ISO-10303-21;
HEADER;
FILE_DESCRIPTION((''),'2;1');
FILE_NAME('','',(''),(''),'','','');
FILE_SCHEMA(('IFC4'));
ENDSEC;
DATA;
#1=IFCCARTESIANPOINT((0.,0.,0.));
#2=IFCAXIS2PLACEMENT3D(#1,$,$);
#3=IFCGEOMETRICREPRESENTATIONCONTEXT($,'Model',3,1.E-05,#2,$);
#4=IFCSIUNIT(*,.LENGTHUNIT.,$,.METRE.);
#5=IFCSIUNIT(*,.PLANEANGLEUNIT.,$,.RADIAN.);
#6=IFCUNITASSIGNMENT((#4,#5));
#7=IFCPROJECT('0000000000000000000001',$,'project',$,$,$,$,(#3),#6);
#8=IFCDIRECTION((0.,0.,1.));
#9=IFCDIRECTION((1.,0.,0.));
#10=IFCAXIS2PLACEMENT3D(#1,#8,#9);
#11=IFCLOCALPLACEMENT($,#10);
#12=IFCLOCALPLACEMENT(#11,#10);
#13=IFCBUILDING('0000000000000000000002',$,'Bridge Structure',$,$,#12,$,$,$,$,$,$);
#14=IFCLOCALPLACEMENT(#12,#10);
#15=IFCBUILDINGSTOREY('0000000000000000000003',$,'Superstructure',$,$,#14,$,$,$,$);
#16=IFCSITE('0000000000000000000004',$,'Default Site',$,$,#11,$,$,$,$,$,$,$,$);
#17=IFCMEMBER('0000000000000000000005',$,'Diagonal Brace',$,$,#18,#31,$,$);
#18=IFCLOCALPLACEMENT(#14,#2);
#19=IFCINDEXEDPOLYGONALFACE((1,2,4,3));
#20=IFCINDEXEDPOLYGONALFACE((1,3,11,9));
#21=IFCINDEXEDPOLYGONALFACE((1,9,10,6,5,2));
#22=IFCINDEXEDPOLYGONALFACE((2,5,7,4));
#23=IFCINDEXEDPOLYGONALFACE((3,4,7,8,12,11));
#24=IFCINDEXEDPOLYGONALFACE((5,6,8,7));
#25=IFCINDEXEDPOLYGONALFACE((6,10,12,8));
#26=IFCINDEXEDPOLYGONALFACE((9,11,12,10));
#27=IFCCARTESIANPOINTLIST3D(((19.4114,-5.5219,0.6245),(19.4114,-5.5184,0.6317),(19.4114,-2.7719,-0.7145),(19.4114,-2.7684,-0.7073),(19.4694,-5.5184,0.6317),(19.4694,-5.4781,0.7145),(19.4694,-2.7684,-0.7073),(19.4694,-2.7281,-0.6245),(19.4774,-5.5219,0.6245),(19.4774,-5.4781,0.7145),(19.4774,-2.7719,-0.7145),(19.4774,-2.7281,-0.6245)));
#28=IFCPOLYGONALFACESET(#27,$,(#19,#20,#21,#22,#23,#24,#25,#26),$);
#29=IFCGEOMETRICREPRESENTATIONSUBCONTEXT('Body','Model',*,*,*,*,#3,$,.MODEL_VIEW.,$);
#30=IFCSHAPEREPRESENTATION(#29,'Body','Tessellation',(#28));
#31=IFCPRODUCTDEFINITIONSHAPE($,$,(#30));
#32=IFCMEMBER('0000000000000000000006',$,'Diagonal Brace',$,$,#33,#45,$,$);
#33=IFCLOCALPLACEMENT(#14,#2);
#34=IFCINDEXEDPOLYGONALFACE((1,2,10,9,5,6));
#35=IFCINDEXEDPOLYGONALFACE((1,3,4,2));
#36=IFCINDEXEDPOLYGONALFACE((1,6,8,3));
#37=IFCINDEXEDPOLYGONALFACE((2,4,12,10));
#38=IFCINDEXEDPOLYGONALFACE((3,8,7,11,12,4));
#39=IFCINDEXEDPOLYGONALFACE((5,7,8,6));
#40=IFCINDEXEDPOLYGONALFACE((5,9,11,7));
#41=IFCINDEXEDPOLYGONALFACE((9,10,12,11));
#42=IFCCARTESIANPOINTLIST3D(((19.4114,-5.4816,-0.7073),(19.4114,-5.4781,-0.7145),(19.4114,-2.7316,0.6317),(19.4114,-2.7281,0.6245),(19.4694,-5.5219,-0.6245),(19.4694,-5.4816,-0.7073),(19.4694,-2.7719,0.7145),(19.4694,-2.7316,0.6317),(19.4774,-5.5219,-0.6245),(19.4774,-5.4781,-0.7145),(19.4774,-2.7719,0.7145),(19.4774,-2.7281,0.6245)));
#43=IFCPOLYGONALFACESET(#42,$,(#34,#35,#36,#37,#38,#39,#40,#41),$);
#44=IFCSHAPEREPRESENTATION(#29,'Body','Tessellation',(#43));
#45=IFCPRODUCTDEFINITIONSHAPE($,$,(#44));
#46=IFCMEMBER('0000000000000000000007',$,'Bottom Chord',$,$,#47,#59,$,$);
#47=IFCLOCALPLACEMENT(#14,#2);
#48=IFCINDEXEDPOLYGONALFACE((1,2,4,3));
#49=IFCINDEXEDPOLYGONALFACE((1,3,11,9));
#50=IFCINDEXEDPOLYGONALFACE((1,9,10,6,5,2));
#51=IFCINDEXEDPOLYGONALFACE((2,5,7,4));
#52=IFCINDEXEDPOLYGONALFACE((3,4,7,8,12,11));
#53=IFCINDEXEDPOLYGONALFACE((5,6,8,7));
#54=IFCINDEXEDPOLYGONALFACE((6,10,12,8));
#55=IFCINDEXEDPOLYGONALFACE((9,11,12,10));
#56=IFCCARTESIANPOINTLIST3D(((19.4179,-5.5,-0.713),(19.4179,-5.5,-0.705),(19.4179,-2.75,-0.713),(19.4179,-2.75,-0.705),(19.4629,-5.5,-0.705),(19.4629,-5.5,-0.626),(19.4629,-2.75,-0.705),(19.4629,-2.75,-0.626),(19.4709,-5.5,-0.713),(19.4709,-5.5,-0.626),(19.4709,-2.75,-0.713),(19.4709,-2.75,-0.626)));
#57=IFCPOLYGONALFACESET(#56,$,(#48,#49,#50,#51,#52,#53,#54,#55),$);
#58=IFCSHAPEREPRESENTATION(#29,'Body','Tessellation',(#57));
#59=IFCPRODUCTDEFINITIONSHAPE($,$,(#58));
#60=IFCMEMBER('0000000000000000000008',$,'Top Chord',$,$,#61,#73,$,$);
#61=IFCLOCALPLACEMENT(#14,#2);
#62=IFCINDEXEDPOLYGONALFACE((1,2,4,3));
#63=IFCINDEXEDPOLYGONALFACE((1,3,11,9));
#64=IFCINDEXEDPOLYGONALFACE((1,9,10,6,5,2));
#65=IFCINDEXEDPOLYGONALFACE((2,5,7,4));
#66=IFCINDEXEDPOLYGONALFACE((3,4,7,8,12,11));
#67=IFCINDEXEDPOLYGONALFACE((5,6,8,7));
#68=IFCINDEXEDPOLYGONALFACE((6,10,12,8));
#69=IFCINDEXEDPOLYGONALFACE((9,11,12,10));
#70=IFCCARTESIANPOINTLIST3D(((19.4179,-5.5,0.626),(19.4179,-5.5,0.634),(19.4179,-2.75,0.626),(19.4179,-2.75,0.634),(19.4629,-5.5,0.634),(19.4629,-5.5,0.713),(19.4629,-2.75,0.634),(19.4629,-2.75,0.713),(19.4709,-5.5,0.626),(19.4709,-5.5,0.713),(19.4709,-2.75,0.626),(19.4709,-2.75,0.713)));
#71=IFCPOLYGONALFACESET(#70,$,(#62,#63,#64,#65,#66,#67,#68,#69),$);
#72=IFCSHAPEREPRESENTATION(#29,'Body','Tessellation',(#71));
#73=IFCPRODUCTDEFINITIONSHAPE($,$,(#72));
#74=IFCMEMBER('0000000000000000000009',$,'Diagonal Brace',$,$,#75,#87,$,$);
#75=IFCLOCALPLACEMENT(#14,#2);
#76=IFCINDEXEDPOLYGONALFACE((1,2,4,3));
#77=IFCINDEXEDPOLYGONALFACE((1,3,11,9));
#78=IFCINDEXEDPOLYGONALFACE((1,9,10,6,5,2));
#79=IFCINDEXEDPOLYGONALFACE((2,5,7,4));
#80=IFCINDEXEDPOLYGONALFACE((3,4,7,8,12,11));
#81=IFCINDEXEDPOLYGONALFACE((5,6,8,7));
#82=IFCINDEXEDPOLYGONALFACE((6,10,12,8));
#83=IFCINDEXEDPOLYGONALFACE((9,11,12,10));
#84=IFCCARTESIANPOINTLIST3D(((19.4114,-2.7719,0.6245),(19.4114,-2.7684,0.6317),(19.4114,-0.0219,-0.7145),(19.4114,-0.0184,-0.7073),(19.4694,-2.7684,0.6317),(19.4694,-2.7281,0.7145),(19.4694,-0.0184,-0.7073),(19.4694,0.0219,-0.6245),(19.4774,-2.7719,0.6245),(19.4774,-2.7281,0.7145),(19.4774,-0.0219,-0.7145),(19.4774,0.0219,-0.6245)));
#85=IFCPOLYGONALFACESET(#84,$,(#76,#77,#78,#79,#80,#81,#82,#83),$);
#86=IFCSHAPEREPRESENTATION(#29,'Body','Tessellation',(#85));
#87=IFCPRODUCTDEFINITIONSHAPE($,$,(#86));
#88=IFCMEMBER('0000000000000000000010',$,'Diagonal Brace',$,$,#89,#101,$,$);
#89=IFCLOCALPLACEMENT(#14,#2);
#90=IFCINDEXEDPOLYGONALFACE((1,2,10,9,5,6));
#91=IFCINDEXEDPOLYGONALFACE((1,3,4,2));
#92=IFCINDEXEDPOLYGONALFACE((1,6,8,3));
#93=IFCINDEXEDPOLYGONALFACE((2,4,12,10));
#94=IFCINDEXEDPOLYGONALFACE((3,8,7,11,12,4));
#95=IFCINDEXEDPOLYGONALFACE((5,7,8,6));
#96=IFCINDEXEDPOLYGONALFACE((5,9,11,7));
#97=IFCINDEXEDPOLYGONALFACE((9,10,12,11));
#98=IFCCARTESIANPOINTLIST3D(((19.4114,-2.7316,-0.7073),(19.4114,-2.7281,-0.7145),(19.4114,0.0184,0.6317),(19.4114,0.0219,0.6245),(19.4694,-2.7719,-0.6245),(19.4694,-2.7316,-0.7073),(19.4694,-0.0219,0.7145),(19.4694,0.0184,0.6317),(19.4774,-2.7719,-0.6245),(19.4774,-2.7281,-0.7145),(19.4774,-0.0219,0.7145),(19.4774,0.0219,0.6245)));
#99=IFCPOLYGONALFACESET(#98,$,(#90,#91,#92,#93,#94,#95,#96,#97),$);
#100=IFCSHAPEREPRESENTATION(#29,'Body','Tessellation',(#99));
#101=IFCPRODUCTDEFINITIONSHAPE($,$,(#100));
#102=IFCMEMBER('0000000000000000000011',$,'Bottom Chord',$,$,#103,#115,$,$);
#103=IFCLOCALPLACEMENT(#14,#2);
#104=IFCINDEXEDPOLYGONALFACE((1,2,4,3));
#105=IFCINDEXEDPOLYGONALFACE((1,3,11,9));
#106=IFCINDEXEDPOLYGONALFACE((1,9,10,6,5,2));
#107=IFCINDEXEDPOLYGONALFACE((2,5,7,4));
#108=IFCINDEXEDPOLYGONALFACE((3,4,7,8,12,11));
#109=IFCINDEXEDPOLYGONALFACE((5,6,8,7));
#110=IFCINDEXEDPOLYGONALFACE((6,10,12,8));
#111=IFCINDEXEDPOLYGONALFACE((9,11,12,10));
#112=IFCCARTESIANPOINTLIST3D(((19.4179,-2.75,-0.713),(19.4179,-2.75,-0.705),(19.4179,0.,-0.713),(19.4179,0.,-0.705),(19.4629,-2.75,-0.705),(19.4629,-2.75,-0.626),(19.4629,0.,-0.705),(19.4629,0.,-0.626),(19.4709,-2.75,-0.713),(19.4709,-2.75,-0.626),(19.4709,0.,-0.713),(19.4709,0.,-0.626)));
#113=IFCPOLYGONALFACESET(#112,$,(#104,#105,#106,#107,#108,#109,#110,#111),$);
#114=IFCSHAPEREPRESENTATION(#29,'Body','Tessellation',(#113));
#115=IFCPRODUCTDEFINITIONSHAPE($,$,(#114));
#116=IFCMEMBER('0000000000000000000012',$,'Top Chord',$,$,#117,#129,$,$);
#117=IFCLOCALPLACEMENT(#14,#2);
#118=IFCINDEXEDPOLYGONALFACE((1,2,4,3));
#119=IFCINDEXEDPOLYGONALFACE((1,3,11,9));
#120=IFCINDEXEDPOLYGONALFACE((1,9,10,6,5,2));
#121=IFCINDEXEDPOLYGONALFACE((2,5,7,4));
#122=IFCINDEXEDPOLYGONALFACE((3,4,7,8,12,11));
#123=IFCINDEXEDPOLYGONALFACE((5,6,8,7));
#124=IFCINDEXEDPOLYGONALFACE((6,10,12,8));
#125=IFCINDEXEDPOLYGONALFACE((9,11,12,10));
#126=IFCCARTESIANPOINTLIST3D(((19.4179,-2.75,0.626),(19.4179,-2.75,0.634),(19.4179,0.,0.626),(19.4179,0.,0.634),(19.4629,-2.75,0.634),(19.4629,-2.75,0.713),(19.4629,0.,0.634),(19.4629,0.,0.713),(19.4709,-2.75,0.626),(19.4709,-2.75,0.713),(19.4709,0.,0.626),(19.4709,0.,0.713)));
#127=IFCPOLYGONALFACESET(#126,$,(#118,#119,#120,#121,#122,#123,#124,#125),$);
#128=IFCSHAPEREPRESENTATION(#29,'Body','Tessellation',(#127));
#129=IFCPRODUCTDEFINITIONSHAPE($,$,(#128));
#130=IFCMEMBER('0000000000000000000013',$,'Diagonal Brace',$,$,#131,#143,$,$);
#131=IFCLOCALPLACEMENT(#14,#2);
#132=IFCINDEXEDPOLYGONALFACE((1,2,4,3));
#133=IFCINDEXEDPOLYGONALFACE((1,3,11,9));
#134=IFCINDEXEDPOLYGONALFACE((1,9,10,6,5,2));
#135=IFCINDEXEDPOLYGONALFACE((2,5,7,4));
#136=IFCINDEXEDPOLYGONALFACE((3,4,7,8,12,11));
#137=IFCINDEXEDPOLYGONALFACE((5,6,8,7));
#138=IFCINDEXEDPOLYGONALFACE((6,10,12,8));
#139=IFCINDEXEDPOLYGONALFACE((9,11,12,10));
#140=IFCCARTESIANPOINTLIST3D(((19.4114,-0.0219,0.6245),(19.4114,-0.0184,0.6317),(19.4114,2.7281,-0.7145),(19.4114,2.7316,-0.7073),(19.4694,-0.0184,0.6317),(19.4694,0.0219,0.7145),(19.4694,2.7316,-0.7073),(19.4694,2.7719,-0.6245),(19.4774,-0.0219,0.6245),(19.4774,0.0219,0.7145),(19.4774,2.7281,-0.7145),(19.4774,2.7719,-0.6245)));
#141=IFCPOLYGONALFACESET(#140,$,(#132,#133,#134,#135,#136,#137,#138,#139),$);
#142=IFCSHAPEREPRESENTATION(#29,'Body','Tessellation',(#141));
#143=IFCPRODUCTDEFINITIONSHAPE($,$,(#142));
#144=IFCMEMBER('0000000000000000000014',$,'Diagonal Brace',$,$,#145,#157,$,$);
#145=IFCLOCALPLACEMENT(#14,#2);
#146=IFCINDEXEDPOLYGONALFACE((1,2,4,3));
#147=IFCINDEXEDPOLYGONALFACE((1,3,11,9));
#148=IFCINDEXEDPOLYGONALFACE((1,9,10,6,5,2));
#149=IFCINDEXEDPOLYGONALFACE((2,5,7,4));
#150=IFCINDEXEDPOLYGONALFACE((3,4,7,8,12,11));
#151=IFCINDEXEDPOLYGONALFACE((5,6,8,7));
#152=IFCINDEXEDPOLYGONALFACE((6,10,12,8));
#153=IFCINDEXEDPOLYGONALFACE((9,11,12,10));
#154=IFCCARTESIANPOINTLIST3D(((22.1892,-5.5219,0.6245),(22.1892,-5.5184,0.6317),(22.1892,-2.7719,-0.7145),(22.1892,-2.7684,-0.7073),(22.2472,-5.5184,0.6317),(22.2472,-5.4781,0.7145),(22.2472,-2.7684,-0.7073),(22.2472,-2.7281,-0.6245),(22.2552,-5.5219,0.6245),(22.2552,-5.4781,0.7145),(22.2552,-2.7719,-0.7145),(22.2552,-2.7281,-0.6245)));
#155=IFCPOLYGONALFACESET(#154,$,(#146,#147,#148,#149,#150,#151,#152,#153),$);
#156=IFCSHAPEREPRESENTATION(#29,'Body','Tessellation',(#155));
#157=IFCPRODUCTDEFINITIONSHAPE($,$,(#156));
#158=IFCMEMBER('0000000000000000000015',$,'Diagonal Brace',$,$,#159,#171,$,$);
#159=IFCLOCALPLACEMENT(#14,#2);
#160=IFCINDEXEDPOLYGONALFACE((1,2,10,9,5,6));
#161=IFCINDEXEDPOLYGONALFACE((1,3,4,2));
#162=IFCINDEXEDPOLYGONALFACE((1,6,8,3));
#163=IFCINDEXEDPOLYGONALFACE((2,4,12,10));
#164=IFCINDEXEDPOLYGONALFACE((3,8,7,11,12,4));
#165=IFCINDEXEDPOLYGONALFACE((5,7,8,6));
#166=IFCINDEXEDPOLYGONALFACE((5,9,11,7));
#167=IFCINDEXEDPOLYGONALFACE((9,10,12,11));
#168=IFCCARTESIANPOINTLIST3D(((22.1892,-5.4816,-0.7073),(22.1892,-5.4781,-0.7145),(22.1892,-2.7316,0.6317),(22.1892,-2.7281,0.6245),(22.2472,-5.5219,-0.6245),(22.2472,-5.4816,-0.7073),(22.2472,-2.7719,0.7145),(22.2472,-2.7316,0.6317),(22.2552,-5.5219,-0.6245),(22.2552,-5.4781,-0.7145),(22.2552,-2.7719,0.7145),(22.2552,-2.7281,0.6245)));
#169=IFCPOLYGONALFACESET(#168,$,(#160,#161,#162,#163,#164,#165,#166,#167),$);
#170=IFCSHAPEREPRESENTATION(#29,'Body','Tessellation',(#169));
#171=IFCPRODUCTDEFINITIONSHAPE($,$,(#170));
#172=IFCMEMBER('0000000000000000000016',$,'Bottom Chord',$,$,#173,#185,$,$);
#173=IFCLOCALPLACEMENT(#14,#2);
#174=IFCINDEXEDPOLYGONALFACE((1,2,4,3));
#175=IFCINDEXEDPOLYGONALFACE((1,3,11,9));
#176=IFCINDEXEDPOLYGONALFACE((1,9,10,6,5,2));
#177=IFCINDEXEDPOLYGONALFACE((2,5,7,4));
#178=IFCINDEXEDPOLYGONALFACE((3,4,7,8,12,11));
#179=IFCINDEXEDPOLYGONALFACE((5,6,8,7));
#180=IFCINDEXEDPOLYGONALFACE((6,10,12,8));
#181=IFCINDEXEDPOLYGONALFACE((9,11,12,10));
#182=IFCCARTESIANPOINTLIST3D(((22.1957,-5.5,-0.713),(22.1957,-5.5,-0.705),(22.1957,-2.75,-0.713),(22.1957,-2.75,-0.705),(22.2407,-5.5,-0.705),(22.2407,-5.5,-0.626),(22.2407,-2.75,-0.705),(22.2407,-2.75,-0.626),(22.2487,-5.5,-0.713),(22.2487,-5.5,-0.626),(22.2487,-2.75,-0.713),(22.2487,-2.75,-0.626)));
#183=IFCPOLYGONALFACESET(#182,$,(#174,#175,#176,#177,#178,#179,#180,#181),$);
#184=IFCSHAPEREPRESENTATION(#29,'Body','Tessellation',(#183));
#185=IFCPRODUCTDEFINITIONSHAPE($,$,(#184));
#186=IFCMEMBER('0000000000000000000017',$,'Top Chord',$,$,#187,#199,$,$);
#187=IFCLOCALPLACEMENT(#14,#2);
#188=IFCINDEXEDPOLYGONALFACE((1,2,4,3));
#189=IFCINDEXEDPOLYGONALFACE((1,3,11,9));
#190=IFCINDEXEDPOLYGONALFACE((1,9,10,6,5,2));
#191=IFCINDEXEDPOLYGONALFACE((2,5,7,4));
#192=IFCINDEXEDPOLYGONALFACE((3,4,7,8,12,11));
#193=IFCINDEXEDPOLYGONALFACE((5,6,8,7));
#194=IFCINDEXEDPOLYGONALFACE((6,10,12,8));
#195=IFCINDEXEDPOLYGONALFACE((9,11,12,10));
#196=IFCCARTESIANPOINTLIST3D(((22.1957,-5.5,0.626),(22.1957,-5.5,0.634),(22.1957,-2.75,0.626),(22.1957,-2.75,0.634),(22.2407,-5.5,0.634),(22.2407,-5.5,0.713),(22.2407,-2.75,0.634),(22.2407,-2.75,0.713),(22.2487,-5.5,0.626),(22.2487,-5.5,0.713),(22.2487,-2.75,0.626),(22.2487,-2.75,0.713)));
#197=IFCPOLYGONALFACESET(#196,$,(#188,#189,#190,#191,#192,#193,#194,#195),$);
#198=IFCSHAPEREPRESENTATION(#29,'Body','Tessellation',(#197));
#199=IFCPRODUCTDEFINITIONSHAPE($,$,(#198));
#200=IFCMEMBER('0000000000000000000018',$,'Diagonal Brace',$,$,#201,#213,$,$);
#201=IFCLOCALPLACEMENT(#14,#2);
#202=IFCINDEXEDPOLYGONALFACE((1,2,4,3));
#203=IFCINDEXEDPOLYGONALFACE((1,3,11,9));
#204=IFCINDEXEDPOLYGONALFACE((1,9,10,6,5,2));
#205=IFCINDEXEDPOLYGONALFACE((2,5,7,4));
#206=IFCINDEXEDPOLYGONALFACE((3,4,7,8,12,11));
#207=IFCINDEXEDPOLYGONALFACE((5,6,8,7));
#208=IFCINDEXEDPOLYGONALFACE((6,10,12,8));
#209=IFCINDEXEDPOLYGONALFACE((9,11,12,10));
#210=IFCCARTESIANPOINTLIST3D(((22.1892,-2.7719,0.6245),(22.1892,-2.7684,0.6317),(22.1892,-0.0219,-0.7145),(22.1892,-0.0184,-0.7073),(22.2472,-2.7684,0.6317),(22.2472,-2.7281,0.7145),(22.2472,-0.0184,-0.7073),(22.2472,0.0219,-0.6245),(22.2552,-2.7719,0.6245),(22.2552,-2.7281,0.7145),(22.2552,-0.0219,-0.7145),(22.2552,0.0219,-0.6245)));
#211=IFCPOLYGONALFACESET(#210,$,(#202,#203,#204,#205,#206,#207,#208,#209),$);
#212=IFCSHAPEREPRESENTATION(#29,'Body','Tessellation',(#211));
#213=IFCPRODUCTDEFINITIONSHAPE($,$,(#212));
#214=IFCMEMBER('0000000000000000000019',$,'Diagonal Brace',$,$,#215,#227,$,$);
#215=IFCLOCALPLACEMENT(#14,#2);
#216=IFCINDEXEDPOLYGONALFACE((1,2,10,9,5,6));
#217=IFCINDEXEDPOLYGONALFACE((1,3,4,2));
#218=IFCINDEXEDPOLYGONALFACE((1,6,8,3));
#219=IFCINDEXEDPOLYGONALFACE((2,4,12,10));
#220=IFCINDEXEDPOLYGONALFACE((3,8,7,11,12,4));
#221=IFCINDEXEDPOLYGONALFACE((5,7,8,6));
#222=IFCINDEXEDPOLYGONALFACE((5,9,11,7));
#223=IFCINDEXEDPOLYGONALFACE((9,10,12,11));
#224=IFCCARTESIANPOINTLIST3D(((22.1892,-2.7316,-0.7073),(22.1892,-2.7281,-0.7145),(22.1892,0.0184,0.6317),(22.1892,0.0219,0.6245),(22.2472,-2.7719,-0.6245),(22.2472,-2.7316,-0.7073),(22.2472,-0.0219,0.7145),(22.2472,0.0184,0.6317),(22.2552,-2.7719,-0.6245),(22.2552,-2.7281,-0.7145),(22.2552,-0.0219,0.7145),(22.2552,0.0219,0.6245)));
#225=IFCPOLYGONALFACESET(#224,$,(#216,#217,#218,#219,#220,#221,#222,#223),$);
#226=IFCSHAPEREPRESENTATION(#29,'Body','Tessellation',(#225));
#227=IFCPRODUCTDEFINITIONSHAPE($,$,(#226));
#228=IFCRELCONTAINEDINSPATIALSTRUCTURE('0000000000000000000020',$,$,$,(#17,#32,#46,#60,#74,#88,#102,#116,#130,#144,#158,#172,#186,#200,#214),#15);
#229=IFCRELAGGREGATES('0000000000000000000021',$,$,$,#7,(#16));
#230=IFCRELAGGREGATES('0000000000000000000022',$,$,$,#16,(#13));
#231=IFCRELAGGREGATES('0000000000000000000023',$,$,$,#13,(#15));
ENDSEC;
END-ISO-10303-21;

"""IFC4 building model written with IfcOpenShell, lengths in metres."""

from ifc_helpers import new_model, si_unit, frame, origin, origin_with_axes, origin_2d_with_axis, place, context, subcontext, project, spatial, l_section, extrude, element, save


model = new_model("IFC4")

# Units and contexts
model_context = context("Model", 3, precision=1e-05, world=origin())
body_context = subcontext(model_context, "Body", "Model", "MODEL_VIEW")
ifc_project = project(units=[si_unit("LENGTHUNIT", "METRE"), si_unit("PLANEANGLEUNIT", "RADIAN")], contexts=[model_context])

# Site, building, storey
site_placement = place(None, origin_with_axes())
site = spatial("IfcSite", under=ifc_project, at=site_placement, Name="Default Site")
building_placement = place(site_placement, origin_with_axes())
building = spatial("IfcBuilding", under=site, at=building_placement, Name="Bridge Structure")
storey_placement = place(building_placement, origin_with_axes())
storey = spatial("IfcBuildingStorey", under=building, at=storey_placement, Name="Superstructure")

# Members
for number, where, z_axis, x_axis, name in (
    (1, (19.4444, -5.5, 0.6695), (0.0, 0.899086, -0.437773), (-1.0, 0.0, 0.0), "Diagonal Brace"),
    (2, (19.4444, -5.5, -0.6695), (0.0, 0.899086, 0.437773), (-1.0, 0.0, 0.0), "Diagonal Brace"),
):
    element("IfcMember", number, at=place(storey_placement, frame(where, z_axis=z_axis, x_axis=x_axis)), inside=storey, Name=name, context=body_context, shape_type="SweptSolid", body=[
        extrude(l_section(Depth=0.1, Width=0.066, Thickness=0.008, at=origin_2d_with_axis()), origin_with_axes(), (0.0, 0.0, 1.0), 3.0587),
    ])
for number, where, z_axis, x_axis, name in (
    (3, (19.4444, -5.5, -0.6695), (0.0, 1.0, 0.0), (-1.0, 0.0, 0.0), "Bottom Chord"),
    (4, (19.4444, -5.5, 0.6695), (0.0, 1.0, 0.0), (-1.0, 0.0, 0.0), "Top Chord"),
):
    element("IfcMember", number, at=place(storey_placement, frame(where, z_axis=z_axis, x_axis=x_axis)), inside=storey, Name=name, context=body_context, shape_type="SweptSolid", body=[
        extrude(l_section(Depth=0.087, Width=0.053, Thickness=0.008, at=origin_2d_with_axis()), origin_with_axes(), (0.0, 0.0, 1.0), 2.75),
    ])
for number, where, z_axis, x_axis, name in (
    (5, (19.4444, -2.75, 0.6695), (0.0, 0.899086, -0.437773), (-1.0, 0.0, 0.0), "Diagonal Brace"),
    (6, (19.4444, -2.75, -0.6695), (0.0, 0.899086, 0.437773), (-1.0, 0.0, 0.0), "Diagonal Brace"),
):
    element("IfcMember", number, at=place(storey_placement, frame(where, z_axis=z_axis, x_axis=x_axis)), inside=storey, Name=name, context=body_context, shape_type="SweptSolid", body=[
        extrude(l_section(Depth=0.1, Width=0.066, Thickness=0.008, at=origin_2d_with_axis()), origin_with_axes(), (0.0, 0.0, 1.0), 3.0587),
    ])
for number, where, z_axis, x_axis, name in (
    (7, (19.4444, -2.75, -0.6695), (0.0, 1.0, 0.0), (-1.0, 0.0, 0.0), "Bottom Chord"),
    (8, (19.4444, -2.75, 0.6695), (0.0, 1.0, 0.0), (-1.0, 0.0, 0.0), "Top Chord"),
):
    element("IfcMember", number, at=place(storey_placement, frame(where, z_axis=z_axis, x_axis=x_axis)), inside=storey, Name=name, context=body_context, shape_type="SweptSolid", body=[
        extrude(l_section(Depth=0.087, Width=0.053, Thickness=0.008, at=origin_2d_with_axis()), origin_with_axes(), (0.0, 0.0, 1.0), 2.75),
    ])
for number, where, z_axis, x_axis, name in (
    (9, (19.4444, 0.0, 0.6695), (0.0, 0.899086, -0.437773), (-1.0, 0.0, 0.0), "Diagonal Brace"),
    (10, (22.2222, -5.5, 0.6695), (0.0, 0.899086, -0.437773), (-1.0, 0.0, 0.0), "Diagonal Brace"),
    (11, (22.2222, -5.5, -0.6695), (0.0, 0.899086, 0.437773), (-1.0, 0.0, 0.0), "Diagonal Brace"),
):
    element("IfcMember", number, at=place(storey_placement, frame(where, z_axis=z_axis, x_axis=x_axis)), inside=storey, Name=name, context=body_context, shape_type="SweptSolid", body=[
        extrude(l_section(Depth=0.1, Width=0.066, Thickness=0.008, at=origin_2d_with_axis()), origin_with_axes(), (0.0, 0.0, 1.0), 3.0587),
    ])
for number, where, z_axis, x_axis, name in (
    (12, (22.2222, -5.5, -0.6695), (0.0, 1.0, 0.0), (-1.0, 0.0, 0.0), "Bottom Chord"),
    (13, (22.2222, -5.5, 0.6695), (0.0, 1.0, 0.0), (-1.0, 0.0, 0.0), "Top Chord"),
):
    element("IfcMember", number, at=place(storey_placement, frame(where, z_axis=z_axis, x_axis=x_axis)), inside=storey, Name=name, context=body_context, shape_type="SweptSolid", body=[
        extrude(l_section(Depth=0.087, Width=0.053, Thickness=0.008, at=origin_2d_with_axis()), origin_with_axes(), (0.0, 0.0, 1.0), 2.75),
    ])
for number, where, z_axis, x_axis, name in (
    (14, (22.2222, -2.75, 0.6695), (0.0, 0.899086, -0.437773), (-1.0, 0.0, 0.0), "Diagonal Brace"),
    (15, (22.2222, -2.75, -0.6695), (0.0, 0.899086, 0.437773), (-1.0, 0.0, 0.0), "Diagonal Brace"),
):
    element("IfcMember", number, at=place(storey_placement, frame(where, z_axis=z_axis, x_axis=x_axis)), inside=storey, Name=name, context=body_context, shape_type="SweptSolid", body=[
        extrude(l_section(Depth=0.1, Width=0.066, Thickness=0.008, at=origin_2d_with_axis()), origin_with_axes(), (0.0, 0.0, 1.0), 3.0587),
    ])

save(model, "model.ifc")
